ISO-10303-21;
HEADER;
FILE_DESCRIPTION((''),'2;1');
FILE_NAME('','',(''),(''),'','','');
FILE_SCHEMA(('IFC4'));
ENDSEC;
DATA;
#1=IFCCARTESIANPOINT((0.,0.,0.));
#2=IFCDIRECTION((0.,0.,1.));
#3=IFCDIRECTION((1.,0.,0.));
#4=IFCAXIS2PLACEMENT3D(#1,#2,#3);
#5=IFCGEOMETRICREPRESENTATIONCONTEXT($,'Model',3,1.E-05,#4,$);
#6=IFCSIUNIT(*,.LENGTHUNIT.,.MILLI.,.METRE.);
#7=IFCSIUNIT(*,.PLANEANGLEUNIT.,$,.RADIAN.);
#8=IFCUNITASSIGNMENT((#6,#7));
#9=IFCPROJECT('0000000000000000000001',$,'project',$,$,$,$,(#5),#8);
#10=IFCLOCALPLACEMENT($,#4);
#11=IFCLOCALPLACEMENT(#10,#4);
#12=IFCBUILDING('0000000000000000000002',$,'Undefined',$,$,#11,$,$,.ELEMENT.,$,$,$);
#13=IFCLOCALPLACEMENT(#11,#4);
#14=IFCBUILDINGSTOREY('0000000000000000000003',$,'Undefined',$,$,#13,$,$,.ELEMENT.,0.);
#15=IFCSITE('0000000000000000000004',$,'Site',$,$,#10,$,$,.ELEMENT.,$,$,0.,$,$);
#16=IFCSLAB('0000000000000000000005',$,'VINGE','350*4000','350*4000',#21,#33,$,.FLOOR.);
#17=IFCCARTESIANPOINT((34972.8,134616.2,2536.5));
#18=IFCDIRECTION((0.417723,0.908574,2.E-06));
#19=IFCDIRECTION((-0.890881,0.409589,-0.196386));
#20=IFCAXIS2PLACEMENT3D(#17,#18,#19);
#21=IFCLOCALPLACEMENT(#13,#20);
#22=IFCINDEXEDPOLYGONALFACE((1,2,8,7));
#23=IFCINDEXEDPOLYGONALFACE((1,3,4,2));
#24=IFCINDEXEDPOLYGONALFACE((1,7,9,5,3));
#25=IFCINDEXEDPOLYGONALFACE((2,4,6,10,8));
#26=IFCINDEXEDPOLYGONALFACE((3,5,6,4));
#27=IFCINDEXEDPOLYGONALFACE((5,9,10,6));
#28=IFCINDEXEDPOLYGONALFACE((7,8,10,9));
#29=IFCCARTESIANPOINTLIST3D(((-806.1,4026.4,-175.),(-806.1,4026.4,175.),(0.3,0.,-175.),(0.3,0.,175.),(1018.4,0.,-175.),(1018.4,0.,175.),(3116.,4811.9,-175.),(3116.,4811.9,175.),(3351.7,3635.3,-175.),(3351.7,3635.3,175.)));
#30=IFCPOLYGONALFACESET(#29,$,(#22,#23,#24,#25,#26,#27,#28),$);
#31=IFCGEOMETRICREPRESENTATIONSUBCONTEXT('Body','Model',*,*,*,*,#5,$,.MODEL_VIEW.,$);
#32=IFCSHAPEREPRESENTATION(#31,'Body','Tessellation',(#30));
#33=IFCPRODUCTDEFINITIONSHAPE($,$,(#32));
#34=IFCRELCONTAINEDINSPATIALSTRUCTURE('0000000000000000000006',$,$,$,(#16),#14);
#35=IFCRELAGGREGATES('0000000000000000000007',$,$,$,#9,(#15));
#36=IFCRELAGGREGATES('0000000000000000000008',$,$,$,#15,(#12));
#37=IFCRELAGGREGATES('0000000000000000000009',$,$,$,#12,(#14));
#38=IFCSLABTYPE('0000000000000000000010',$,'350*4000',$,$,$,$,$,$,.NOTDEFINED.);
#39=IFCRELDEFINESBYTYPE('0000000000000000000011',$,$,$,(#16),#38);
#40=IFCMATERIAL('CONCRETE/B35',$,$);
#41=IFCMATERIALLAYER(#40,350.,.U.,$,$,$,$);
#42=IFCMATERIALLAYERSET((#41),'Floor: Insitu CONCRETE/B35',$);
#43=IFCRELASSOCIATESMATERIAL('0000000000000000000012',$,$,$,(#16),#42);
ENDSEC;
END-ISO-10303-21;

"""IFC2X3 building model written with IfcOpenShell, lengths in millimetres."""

from ifc_helpers import new_model, si_unit, frame, origin_with_axes, place, context, subcontext, project, spatial, polyline, outline, extrude, material, layer, layer_set, layer_usage, type_object, element, save


model = new_model("IFC2X3")

# Units and contexts
model_context = context("Model", 3, precision=1e-05, world=origin_with_axes())
body_context = subcontext(model_context, "Body", "Model", "MODEL_VIEW")
ifc_project = project(units=[si_unit("LENGTHUNIT", "METRE", prefix="MILLI"), si_unit("PLANEANGLEUNIT", "RADIAN")], contexts=[model_context])

# Site, building, storey
site_placement = place(None, origin_with_axes())
site = spatial("IfcSite", under=ifc_project, at=site_placement, Name="Site", CompositionType="ELEMENT", RefElevation=0.0)
building_placement = place(site_placement, origin_with_axes())
building = spatial("IfcBuilding", under=site, at=building_placement, Name="Undefined", CompositionType="ELEMENT")
storey_placement = place(building_placement, origin_with_axes())
storey = spatial("IfcBuildingStorey", under=building, at=storey_placement, Name="Undefined", CompositionType="ELEMENT", Elevation=0.0)

# Shared definitions
ifc_material_1 = material(Name="CONCRETE/B35")

# Slab
ifc_layer_1 = layer(ifc_material_1, 350.0, ventilated="UNKNOWN")
ifc_layer_set_1 = layer_set([ifc_layer_1], Name="Floor: Insitu CONCRETE/B35")
ifc_layer_usage_1 = layer_usage(ifc_layer_set_1, "AXIS3", "POSITIVE", -175.0)
slab_type_1 = type_object("IfcSlabType", Name="350*4000", PredefinedType="NOTDEFINED")
slab_1_placement = place(storey_placement, frame((34972.8, 134616.2, 2536.5), z_axis=(0.417723, 0.908574, 0.000002), x_axis=(-0.890881, 0.409589, -0.196386)))
element("IfcSlab", 1, at=slab_1_placement, inside=storey, type_object=slab_type_1, material=ifc_layer_usage_1, Name="VINGE", Description="350*4000", ObjectType="350*4000", PredefinedType="FLOOR", context=body_context, shape_type="SweptSolid", body=[
    extrude(outline(polyline([(0.0, 0.0), (1018.4, 0.0), (3351.7, 3635.3), (3116.0, 4811.9), (-806.1, 4026.4), (0.3, 0.1), (0.0, 0.0)])), frame((0.0, 0.0, -175.0), z_axis=(0.0, 0.0, 1.0), x_axis=(1.0, 0.0, 0.0)), (0.0, 0.0, 1.0), 350.0),
])

save(model, "model.ifc")
